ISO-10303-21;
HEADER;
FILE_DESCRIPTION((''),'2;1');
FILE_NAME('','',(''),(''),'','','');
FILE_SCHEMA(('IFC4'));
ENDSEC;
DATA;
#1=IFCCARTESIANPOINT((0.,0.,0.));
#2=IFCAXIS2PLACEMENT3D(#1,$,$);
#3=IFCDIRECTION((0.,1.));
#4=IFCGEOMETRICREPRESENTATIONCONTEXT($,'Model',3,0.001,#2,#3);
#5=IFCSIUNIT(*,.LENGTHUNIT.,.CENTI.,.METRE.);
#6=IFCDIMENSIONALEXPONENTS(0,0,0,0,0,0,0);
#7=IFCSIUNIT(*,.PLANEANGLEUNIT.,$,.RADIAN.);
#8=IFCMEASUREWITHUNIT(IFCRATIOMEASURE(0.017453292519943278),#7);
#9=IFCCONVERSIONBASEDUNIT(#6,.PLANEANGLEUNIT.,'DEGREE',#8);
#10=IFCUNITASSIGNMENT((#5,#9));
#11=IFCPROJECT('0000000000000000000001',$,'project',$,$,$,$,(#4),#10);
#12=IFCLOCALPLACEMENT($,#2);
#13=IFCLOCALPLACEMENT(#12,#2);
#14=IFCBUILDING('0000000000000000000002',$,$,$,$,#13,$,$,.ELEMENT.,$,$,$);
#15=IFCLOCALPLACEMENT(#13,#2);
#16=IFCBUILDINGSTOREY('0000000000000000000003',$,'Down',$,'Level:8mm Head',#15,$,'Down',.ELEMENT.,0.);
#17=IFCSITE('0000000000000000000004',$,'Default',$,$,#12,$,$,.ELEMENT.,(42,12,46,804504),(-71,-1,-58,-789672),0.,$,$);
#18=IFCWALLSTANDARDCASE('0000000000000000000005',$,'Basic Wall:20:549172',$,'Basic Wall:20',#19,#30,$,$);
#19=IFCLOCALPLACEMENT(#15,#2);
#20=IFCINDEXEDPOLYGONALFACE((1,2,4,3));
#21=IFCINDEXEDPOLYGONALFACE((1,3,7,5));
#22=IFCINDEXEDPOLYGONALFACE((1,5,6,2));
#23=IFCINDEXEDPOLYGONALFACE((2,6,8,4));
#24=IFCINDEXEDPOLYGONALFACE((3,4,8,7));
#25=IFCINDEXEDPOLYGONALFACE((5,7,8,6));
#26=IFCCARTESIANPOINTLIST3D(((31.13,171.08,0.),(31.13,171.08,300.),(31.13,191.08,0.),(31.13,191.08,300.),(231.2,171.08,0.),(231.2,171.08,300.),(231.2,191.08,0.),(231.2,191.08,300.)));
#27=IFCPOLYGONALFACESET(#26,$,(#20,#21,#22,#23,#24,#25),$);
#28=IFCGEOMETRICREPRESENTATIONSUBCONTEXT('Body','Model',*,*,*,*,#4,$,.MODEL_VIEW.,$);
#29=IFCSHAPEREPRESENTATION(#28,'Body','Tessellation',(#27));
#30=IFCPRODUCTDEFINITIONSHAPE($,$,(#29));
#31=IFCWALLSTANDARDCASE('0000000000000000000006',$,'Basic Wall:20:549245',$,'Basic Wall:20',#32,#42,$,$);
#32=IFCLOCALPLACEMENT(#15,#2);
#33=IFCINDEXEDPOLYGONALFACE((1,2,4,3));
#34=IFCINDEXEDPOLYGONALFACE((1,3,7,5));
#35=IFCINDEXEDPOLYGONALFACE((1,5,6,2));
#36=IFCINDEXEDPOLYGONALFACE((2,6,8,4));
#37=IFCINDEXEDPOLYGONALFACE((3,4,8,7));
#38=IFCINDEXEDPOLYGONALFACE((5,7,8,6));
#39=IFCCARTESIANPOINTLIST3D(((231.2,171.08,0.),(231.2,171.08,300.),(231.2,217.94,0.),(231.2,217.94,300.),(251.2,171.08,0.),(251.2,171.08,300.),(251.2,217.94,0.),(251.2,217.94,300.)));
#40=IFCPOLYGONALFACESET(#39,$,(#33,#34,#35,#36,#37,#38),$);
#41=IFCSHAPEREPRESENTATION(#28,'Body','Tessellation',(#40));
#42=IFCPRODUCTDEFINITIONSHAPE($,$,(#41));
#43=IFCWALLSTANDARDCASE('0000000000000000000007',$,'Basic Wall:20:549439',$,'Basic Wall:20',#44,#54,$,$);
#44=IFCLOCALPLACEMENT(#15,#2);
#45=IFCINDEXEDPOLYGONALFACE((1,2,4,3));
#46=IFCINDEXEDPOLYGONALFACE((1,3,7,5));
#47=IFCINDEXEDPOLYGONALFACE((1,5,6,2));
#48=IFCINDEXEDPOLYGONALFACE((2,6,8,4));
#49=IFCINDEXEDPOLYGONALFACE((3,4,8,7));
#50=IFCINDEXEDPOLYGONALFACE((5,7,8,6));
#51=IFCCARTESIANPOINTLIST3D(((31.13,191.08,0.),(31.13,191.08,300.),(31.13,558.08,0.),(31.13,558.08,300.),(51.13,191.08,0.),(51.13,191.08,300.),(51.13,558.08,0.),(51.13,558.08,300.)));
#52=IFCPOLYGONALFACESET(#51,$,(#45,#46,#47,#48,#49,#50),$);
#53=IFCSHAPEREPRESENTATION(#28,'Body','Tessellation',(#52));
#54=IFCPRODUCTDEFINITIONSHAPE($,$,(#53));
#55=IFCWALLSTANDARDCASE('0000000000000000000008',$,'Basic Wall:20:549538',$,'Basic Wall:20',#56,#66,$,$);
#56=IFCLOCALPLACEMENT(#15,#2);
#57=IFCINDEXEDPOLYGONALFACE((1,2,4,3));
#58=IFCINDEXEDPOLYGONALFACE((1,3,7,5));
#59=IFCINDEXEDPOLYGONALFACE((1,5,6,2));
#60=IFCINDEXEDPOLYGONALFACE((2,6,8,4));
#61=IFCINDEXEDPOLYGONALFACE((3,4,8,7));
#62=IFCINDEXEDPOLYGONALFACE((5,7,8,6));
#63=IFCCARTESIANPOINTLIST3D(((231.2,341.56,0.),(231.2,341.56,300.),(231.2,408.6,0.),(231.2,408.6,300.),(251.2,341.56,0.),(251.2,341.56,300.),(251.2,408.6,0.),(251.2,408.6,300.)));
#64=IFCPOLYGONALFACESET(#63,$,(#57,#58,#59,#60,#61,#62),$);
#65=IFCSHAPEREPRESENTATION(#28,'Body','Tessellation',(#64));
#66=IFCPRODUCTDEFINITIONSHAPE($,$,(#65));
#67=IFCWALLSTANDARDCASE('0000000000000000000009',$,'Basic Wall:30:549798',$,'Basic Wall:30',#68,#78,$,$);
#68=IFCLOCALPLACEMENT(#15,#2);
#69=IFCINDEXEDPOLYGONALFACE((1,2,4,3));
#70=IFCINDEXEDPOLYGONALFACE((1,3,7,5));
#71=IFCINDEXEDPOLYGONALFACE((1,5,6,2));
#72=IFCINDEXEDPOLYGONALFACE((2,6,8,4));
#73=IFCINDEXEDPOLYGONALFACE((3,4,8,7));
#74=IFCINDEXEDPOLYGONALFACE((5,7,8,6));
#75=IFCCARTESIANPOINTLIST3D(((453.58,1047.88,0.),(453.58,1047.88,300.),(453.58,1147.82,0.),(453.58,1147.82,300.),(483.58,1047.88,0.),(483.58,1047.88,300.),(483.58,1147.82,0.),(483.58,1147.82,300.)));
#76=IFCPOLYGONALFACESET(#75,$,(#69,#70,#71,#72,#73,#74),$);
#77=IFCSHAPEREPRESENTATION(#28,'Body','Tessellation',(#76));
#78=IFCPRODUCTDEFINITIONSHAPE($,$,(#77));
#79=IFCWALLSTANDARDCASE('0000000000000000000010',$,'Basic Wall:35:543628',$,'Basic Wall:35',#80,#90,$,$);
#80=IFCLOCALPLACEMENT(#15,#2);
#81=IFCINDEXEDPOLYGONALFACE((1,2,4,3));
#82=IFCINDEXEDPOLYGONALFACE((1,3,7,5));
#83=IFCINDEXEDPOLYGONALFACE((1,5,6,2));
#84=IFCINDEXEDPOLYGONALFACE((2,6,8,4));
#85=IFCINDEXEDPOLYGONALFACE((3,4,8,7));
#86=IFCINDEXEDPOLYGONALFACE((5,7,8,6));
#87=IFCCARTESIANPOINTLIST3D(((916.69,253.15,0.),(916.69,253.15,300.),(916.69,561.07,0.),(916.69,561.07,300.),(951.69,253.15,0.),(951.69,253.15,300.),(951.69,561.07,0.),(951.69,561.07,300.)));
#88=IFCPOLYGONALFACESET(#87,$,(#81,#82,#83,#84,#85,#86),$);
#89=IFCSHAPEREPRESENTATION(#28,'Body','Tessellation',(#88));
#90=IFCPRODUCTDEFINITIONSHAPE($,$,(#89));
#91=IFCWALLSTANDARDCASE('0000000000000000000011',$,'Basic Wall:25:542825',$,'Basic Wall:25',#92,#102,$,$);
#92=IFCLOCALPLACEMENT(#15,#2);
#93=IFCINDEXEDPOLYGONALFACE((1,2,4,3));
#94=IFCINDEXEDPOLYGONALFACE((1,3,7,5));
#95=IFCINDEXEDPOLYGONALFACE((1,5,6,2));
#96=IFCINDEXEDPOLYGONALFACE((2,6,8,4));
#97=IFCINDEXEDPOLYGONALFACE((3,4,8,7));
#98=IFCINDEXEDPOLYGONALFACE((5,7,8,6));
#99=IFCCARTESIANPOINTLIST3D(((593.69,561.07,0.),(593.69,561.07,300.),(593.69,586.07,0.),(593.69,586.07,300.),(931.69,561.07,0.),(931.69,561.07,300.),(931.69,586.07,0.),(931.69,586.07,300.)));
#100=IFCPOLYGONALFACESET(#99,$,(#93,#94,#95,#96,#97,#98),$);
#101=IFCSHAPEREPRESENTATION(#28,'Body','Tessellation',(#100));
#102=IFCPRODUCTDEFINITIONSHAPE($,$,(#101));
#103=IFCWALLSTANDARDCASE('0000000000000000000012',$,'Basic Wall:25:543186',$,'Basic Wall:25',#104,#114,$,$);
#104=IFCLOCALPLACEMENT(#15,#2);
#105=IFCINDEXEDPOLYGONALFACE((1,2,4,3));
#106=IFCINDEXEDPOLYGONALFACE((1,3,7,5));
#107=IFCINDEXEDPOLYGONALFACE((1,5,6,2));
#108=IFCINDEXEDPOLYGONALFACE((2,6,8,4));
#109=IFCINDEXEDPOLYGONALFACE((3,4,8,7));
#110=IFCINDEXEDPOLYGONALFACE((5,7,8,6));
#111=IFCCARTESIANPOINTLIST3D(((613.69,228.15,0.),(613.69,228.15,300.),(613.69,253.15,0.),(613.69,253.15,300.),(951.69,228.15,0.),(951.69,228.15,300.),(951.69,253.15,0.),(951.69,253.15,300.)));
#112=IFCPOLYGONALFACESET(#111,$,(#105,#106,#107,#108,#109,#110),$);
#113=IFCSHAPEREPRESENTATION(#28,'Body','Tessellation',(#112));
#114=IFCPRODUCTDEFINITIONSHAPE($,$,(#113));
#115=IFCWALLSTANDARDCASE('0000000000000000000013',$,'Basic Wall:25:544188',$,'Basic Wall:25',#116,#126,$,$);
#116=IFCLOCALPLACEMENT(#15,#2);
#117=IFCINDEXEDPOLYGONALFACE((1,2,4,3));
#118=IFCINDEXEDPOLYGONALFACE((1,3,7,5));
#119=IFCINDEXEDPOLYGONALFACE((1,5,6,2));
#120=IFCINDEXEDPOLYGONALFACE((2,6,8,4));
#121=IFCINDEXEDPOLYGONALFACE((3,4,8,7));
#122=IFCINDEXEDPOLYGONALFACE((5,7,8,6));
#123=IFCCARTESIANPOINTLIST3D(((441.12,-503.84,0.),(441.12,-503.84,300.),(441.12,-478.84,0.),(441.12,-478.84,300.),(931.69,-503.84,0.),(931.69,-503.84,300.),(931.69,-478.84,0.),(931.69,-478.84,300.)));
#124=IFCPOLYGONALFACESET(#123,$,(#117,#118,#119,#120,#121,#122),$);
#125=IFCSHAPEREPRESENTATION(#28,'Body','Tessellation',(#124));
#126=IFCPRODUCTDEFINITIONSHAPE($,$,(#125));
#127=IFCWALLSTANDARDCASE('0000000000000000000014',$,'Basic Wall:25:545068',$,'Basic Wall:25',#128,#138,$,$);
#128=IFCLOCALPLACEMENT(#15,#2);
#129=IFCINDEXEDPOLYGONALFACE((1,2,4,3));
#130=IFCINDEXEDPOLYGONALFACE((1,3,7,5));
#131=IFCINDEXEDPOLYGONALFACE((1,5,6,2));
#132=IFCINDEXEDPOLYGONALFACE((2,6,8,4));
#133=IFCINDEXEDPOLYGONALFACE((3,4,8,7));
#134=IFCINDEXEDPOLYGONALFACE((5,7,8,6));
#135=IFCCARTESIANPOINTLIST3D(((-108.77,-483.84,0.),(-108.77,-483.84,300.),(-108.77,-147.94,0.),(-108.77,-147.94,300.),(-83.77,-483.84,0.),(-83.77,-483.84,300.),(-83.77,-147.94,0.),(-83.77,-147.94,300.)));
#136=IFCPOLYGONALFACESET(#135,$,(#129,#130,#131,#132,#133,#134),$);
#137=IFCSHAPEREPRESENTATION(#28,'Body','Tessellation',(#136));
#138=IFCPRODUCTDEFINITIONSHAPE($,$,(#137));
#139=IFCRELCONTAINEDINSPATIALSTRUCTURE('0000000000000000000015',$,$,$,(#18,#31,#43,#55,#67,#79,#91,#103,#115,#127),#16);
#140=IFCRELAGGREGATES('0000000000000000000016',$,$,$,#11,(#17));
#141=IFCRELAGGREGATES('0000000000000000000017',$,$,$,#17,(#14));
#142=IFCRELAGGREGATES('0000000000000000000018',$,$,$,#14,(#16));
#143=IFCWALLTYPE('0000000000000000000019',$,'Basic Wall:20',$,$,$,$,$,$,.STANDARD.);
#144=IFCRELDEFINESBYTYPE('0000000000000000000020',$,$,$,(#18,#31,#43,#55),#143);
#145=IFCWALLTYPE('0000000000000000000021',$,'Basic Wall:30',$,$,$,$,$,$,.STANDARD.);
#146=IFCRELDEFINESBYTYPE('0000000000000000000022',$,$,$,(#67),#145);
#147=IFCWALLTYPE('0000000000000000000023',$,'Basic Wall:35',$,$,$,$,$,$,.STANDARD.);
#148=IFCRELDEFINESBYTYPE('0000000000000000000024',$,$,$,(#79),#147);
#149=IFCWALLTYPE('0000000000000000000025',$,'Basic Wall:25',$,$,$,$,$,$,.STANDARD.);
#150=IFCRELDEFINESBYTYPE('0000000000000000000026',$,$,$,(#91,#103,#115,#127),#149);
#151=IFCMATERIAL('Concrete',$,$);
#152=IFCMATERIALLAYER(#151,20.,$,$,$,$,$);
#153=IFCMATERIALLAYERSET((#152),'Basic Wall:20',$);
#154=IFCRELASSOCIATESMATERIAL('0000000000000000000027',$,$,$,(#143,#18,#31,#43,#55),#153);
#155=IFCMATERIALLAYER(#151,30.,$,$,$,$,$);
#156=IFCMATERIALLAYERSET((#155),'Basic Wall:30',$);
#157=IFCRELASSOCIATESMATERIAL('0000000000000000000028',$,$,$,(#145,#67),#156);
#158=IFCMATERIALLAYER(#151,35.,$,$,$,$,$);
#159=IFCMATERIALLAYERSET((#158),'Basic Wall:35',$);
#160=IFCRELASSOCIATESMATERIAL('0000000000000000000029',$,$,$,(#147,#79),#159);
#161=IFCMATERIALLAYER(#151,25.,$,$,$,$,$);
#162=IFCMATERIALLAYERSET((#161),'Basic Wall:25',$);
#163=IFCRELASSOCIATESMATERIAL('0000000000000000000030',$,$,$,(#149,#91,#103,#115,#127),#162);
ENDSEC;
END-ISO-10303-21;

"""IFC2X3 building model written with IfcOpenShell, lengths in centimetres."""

from ifc_helpers import new_model, entity, si_unit, converted_unit, direction, frame, frame_2d, origin, place, context, subcontext, project, spatial, rectangle, extrude, material, layer, layer_set, layer_usage, type_object, element, save


model = new_model("IFC2X3")

# Units and contexts
model_context = context("Model", 3, precision=0.001, world=origin(), true_north=direction((0.0, 1.0)))
body_context = subcontext(model_context, "Body", "Model", "MODEL_VIEW")
ifc_project = project(units=[si_unit("LENGTHUNIT", "METRE", prefix="CENTI"), converted_unit("PLANEANGLEUNIT", "DEGREE", entity("IfcRatioMeasure", 0.017453292519943278), si_unit("PLANEANGLEUNIT", "RADIAN"), dimensions=[0, 0, 0, 0, 0, 0, 0])], contexts=[model_context])

# Site, building, storey
site_placement = place(None, origin())
site = spatial("IfcSite", under=ifc_project, at=site_placement, Name="Default", CompositionType="ELEMENT", RefLatitude=(42, 12, 46, 804504), RefLongitude=(-71, -1, -58, -789672), RefElevation=0.0)
building_placement = place(site_placement, origin())
building = spatial("IfcBuilding", under=site, at=building_placement, CompositionType="ELEMENT")
storey_placement = place(building_placement, origin())
storey = spatial("IfcBuildingStorey", under=building, at=storey_placement, Name="Down", ObjectType="Level:8mm Head", LongName="Down", CompositionType="ELEMENT", Elevation=0.0)

# Walls
ifc_material = material(Name="Concrete")
ifc_layer_1 = layer(ifc_material, 20.0)
ifc_layer_set_1 = layer_set([ifc_layer_1], Name="Basic Wall:20")
wall_type_1 = type_object("IfcWallType", Name="Basic Wall:20", PredefinedType="STANDARD", material=ifc_layer_set_1)
ifc_layer_usage_1 = layer_usage(ifc_layer_set_1, "AXIS2", "POSITIVE", -10.0)
wall_1_placement = place(storey_placement, frame((31.13, 181.08, 0.0)))
element("IfcWallStandardCase", 1, at=wall_1_placement, inside=storey, type_object=wall_type_1, material=ifc_layer_usage_1, Name="Basic Wall:20:549172", ObjectType="Basic Wall:20", context=body_context, shape_type="SweptSolid", body=[
    extrude(rectangle(XDim=200.07, YDim=20.0, at=frame_2d((100.04, 0.0), x_axis=(-1.0, 0.0))), origin(), (0.0, 0.0, 1.0), 300.0),
])
ifc_layer_usage_2 = layer_usage(ifc_layer_set_1, "AXIS2", "POSITIVE", -10.0)
wall_2_placement = place(storey_placement, frame((241.2, 171.08, 0.0), z_axis=(0.0, 0.0, 1.0), x_axis=(0.0, 1.0, 0.0)))
element("IfcWallStandardCase", 2, at=wall_2_placement, inside=storey, type_object=wall_type_1, material=ifc_layer_usage_2, Name="Basic Wall:20:549245", ObjectType="Basic Wall:20", context=body_context, shape_type="SweptSolid", body=[
    extrude(rectangle(XDim=46.85, YDim=20.0, at=frame_2d((23.43, 0.0), x_axis=(-1.0, 0.0))), origin(), (0.0, 0.0, 1.0), 300.0),
])
ifc_layer_usage_3 = layer_usage(ifc_layer_set_1, "AXIS2", "NEGATIVE", 10.0)
wall_3_placement = place(storey_placement, frame((41.13, 191.08, 0.0), z_axis=(0.0, 0.0, 1.0), x_axis=(0.0, 1.0, 0.0)))
element("IfcWallStandardCase", 3, at=wall_3_placement, inside=storey, type_object=wall_type_1, material=ifc_layer_usage_3, Name="Basic Wall:20:549439", ObjectType="Basic Wall:20", context=body_context, shape_type="SweptSolid", body=[
    extrude(rectangle(XDim=366.99, YDim=20.0, at=frame_2d((183.5, 0.0), x_axis=(-1.0, 0.0))), origin(), (0.0, 0.0, 1.0), 300.0),
])
ifc_layer_usage_4 = layer_usage(ifc_layer_set_1, "AXIS2", "POSITIVE", -10.0)
wall_4_placement = place(storey_placement, frame((241.2, 341.56, 0.0), z_axis=(0.0, 0.0, 1.0), x_axis=(0.0, 1.0, 0.0)))
element("IfcWallStandardCase", 4, at=wall_4_placement, inside=storey, type_object=wall_type_1, material=ifc_layer_usage_4, Name="Basic Wall:20:549538", ObjectType="Basic Wall:20", context=body_context, shape_type="SweptSolid", body=[
    extrude(rectangle(XDim=67.04, YDim=20.0, at=frame_2d((33.52, 0.0), x_axis=(-1.0, 0.0))), origin(), (0.0, 0.0, 1.0), 300.0),
])
ifc_layer_2 = layer(ifc_material, 30.0)
ifc_layer_set_2 = layer_set([ifc_layer_2], Name="Basic Wall:30")
ifc_layer_usage_5 = layer_usage(ifc_layer_set_2, "AXIS2", "POSITIVE", -15.0)
wall_type_2 = type_object("IfcWallType", Name="Basic Wall:30", PredefinedType="STANDARD", material=ifc_layer_set_2)
wall_5_placement = place(storey_placement, frame((468.58, 1147.82, 0.0), z_axis=(0.0, 0.0, 1.0), x_axis=(0.0, -1.0, 0.0)))
element("IfcWallStandardCase", 5, at=wall_5_placement, inside=storey, type_object=wall_type_2, material=ifc_layer_usage_5, Name="Basic Wall:30:549798", ObjectType="Basic Wall:30", context=body_context, shape_type="SweptSolid", body=[
    extrude(rectangle(XDim=99.94, YDim=30.0, at=frame_2d((49.97, 0.0), x_axis=(-1.0, 0.0))), origin(), (0.0, 0.0, 1.0), 300.0),
])
ifc_layer_3 = layer(ifc_material, 35.0)
ifc_layer_set_3 = layer_set([ifc_layer_3], Name="Basic Wall:35")
ifc_layer_usage_6 = layer_usage(ifc_layer_set_3, "AXIS2", "NEGATIVE", 17.5)
wall_type_3 = type_object("IfcWallType", Name="Basic Wall:35", PredefinedType="STANDARD", material=ifc_layer_set_3)
wall_6_placement = place(storey_placement, frame((934.19, 561.07, 0.0), z_axis=(0.0, 0.0, 1.0), x_axis=(0.0, -1.0, 0.0)))
element("IfcWallStandardCase", 6, at=wall_6_placement, inside=storey, type_object=wall_type_3, material=ifc_layer_usage_6, Name="Basic Wall:35:543628", ObjectType="Basic Wall:35", context=body_context, shape_type="SweptSolid", body=[
    extrude(rectangle(XDim=307.91, YDim=35.0, at=frame_2d((153.96, 0.0), x_axis=(-1.0, 0.0))), origin(), (0.0, 0.0, 1.0), 300.0),
])
ifc_layer_4 = layer(ifc_material, 25.0)
ifc_layer_set_4 = layer_set([ifc_layer_4], Name="Basic Wall:25")
ifc_layer_usage_7 = layer_usage(ifc_layer_set_4, "AXIS2", "POSITIVE", -12.5)
wall_type_4 = type_object("IfcWallType", Name="Basic Wall:25", PredefinedType="STANDARD", material=ifc_layer_set_4)
wall_7_placement = place(storey_placement, frame((931.69, 573.57, 0.0), z_axis=(0.0, 0.0, 1.0), x_axis=(-1.0, 0.0, 0.0)))
element("IfcWallStandardCase", 7, at=wall_7_placement, inside=storey, type_object=wall_type_4, material=ifc_layer_usage_7, Name="Basic Wall:25:542825", ObjectType="Basic Wall:25", context=body_context, shape_type="SweptSolid", body=[
    extrude(rectangle(XDim=338.0, YDim=25.0, at=frame_2d((169.0, 0.0), x_axis=(-1.0, 0.0))), origin(), (0.0, 0.0, 1.0), 300.0),
])
ifc_layer_usage_8 = layer_usage(ifc_layer_set_4, "AXIS2", "POSITIVE", -12.5)
wall_8_placement = place(storey_placement, frame((613.69, 240.65, 0.0)))
element("IfcWallStandardCase", 8, at=wall_8_placement, inside=storey, type_object=wall_type_4, material=ifc_layer_usage_8, Name="Basic Wall:25:543186", ObjectType="Basic Wall:25", context=body_context, shape_type="SweptSolid", body=[
    extrude(rectangle(XDim=338.0, YDim=25.0, at=frame_2d((169.0, 0.0), x_axis=(-1.0, 0.0))), origin(), (0.0, 0.0, 1.0), 300.0),
])
ifc_layer_usage_9 = layer_usage(ifc_layer_set_4, "AXIS2", "NEGATIVE", 12.5)
wall_9_placement = place(storey_placement, frame((931.69, -491.34, 0.0), z_axis=(0.0, 0.0, 1.0), x_axis=(-1.0, 0.0, 0.0)))
element("IfcWallStandardCase", 9, at=wall_9_placement, inside=storey, type_object=wall_type_4, material=ifc_layer_usage_9, Name="Basic Wall:25:544188", ObjectType="Basic Wall:25", context=body_context, shape_type="SweptSolid", body=[
    extrude(rectangle(XDim=490.57, YDim=25.0, at=frame_2d((245.29, 0.0), x_axis=(-1.0, 0.0))), origin(), (0.0, 0.0, 1.0), 300.0),
])
ifc_layer_usage_10 = layer_usage(ifc_layer_set_4, "AXIS2", "POSITIVE", -12.5)
wall_10_placement = place(storey_placement, frame((-96.27, -483.84, 0.0), z_axis=(0.0, 0.0, 1.0), x_axis=(0.0, 1.0, 0.0)))
element("IfcWallStandardCase", 10, at=wall_10_placement, inside=storey, type_object=wall_type_4, material=ifc_layer_usage_10, Name="Basic Wall:25:545068", ObjectType="Basic Wall:25", context=body_context, shape_type="SweptSolid", body=[
    extrude(rectangle(XDim=335.91, YDim=25.0, at=frame_2d((167.95, 0.0), x_axis=(-1.0, 0.0))), origin(), (0.0, 0.0, 1.0), 300.0),
])

save(model, "model.ifc")
